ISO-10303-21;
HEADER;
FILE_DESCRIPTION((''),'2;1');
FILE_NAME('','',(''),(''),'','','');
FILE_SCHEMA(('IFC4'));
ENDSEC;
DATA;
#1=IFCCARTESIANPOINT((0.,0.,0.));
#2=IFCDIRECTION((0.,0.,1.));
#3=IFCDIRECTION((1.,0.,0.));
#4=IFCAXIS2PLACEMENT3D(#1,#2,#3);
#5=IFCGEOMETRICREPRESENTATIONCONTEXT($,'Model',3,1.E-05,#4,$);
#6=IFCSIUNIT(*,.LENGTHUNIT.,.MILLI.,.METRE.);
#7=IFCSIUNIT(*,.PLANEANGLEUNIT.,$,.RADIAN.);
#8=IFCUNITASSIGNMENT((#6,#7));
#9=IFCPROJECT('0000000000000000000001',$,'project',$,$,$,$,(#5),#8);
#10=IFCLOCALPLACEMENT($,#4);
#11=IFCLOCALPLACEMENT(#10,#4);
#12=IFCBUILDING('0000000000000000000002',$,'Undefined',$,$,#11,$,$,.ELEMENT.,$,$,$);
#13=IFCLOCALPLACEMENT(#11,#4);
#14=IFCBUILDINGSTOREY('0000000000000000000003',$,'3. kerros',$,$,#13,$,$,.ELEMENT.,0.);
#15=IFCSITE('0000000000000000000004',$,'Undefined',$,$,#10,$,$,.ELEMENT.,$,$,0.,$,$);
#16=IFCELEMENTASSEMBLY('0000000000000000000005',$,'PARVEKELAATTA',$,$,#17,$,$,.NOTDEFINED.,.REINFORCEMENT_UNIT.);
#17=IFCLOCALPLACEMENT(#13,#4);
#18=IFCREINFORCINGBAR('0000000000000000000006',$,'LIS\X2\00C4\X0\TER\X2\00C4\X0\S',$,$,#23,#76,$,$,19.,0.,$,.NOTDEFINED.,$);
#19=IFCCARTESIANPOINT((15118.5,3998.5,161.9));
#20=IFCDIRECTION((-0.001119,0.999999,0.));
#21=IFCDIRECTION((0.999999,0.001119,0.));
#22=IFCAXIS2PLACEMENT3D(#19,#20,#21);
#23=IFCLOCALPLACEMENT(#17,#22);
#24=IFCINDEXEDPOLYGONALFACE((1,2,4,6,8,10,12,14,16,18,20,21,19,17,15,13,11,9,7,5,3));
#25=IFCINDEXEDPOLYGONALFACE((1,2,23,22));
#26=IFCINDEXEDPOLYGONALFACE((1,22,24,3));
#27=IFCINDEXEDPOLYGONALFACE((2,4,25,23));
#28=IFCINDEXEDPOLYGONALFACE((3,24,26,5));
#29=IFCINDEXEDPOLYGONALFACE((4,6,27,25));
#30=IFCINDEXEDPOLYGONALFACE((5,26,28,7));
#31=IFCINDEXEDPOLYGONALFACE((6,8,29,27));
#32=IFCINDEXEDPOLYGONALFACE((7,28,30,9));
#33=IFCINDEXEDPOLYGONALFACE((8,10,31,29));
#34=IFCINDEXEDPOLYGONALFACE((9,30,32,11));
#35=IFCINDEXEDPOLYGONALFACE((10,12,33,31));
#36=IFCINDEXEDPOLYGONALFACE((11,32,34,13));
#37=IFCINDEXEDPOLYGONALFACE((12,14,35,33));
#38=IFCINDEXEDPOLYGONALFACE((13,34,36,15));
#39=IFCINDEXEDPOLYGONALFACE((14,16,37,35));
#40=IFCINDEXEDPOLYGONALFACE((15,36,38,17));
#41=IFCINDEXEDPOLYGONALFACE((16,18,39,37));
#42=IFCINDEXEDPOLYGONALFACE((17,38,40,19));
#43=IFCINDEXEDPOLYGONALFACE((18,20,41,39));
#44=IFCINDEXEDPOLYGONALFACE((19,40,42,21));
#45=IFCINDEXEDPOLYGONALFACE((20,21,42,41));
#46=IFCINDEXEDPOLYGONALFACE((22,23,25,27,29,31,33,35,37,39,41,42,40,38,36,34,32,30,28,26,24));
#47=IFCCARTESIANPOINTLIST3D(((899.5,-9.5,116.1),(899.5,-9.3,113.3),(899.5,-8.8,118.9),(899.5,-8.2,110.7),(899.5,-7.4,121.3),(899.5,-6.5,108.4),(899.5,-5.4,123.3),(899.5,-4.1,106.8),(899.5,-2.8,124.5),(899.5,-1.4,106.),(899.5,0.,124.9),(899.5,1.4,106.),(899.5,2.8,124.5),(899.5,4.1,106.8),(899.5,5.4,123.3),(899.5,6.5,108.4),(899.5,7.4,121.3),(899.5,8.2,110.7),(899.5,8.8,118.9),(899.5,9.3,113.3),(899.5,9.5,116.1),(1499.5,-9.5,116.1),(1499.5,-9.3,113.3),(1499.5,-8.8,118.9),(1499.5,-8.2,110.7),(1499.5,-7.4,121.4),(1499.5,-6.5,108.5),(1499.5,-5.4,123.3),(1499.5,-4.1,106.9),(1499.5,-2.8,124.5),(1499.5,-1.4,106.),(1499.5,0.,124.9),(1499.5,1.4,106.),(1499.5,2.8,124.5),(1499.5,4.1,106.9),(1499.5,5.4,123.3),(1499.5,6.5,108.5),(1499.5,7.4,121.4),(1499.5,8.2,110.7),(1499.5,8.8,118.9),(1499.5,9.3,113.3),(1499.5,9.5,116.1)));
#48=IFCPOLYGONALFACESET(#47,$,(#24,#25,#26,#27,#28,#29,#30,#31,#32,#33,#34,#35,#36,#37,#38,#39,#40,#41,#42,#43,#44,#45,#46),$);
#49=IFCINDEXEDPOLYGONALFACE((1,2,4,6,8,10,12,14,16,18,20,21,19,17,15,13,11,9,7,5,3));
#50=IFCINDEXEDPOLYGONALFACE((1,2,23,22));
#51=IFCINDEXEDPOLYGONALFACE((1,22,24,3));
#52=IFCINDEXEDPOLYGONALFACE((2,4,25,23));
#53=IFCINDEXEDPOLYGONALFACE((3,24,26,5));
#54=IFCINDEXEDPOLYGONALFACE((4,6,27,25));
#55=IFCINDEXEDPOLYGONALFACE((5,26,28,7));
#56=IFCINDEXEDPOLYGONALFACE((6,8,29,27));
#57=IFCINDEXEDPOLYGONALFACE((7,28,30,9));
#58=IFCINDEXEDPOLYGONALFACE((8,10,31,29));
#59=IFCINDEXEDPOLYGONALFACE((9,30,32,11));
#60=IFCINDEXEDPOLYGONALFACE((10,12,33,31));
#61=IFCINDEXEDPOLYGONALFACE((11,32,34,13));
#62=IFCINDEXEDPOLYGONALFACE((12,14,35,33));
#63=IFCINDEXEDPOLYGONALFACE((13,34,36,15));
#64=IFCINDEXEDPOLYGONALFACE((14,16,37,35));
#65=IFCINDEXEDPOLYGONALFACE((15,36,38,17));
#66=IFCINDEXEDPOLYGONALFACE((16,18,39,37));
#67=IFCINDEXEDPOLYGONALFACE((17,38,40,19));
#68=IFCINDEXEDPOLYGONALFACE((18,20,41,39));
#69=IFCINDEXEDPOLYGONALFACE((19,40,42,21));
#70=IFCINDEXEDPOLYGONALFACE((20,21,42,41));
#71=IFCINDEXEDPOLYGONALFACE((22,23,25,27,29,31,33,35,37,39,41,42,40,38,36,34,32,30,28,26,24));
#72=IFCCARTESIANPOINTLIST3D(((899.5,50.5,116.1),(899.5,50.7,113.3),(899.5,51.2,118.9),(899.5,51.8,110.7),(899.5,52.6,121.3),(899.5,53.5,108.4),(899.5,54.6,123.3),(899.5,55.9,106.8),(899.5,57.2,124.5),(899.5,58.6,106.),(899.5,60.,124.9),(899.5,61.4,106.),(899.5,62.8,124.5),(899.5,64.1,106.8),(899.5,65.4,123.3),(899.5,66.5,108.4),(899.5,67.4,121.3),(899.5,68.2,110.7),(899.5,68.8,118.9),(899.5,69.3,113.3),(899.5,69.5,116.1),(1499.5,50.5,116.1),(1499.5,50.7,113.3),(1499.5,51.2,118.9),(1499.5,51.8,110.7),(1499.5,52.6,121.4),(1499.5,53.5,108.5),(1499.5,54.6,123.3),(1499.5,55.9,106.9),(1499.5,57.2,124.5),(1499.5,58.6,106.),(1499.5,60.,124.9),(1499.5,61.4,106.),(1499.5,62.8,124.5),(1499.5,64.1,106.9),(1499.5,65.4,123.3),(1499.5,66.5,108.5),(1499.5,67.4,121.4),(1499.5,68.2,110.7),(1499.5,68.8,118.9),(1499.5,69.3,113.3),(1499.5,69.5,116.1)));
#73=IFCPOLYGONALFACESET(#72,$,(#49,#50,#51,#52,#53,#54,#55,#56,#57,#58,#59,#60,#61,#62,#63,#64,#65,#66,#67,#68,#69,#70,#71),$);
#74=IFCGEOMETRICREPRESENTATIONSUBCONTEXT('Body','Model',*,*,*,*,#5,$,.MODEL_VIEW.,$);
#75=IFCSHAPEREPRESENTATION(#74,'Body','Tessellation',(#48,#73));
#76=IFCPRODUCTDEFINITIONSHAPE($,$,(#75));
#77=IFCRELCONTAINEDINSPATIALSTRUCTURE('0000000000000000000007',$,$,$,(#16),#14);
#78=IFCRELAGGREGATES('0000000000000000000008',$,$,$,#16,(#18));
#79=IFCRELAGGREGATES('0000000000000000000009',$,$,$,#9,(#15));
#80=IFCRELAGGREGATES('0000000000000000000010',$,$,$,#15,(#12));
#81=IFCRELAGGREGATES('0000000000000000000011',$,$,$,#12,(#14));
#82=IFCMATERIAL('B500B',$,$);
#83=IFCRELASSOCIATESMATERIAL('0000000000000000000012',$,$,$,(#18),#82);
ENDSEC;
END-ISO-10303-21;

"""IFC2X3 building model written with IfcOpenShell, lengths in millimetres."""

from ifc_helpers import new_model, entity, si_unit, frame, origin_with_axes, place, context, subcontext, project, spatial, source, transform, mapped, material, element, aggregate, save


model = new_model("IFC2X3")

# Units and contexts
model_context = context("Model", 3, precision=1e-05, world=origin_with_axes())
body_context = subcontext(model_context, "Body", "Model", "MODEL_VIEW")
ifc_project = project(units=[si_unit("LENGTHUNIT", "METRE", prefix="MILLI"), si_unit("PLANEANGLEUNIT", "RADIAN")], contexts=[model_context])

# Site, building, storey
site_placement = place(None, origin_with_axes())
site = spatial("IfcSite", under=ifc_project, at=site_placement, Name="Undefined", CompositionType="ELEMENT", RefElevation=0.0)
building_placement = place(site_placement, origin_with_axes())
building = spatial("IfcBuilding", under=site, at=building_placement, Name="Undefined", CompositionType="ELEMENT")
storey_placement = place(building_placement, origin_with_axes())
storey = spatial("IfcBuildingStorey", under=building, at=storey_placement, Name="3. kerros", CompositionType="ELEMENT", Elevation=0.0)

# Element assembly, reinforcing bar
assembly_1_placement = place(storey_placement, origin_with_axes())
assembly_1 = element("IfcElementAssembly", 1, at=assembly_1_placement, inside=storey, Name="PARVEKELAATTA", AssemblyPlace="NOTDEFINED", PredefinedType="REINFORCEMENT_UNIT")
ifc_material_1 = material(Name="B500B")
shared_shape_1 = source(origin_with_axes(), body_context, "Body", "AdvancedSweptSolid", [
    entity("IfcSweptDiskSolid", entity("IfcTrimmedCurve", entity("IfcLine", entity("IfcCartesianPoint", [0.0, 0.0, 0.0]), entity("IfcVector", entity("IfcDirection", [1.0, 0.0, 0.000048]), 1.0)), [entity("IfcParameterValue", 0.0)], [entity("IfcParameterValue", 600.0)], True, "PARAMETER"), 9.5, None, 0.0, 600.0),
])
shared_shape_2 = source(origin_with_axes(), body_context, "Body", "AdvancedSweptSolid", [
    entity("IfcSweptDiskSolid", entity("IfcTrimmedCurve", entity("IfcLine", entity("IfcCartesianPoint", [0.0, 0.0, 0.0]), entity("IfcVector", entity("IfcDirection", [1.0, 0.0, 0.000048]), 1.0)), [entity("IfcParameterValue", 0.0)], [entity("IfcParameterValue", 600.0)], True, "PARAMETER"), 9.5, None, 0.0, 600.0),
])
reinforcing_bar_1_placement = place(assembly_1_placement, frame((15118.5, 3998.5, 161.9), z_axis=(-0.001119, 0.999999, 0.0), x_axis=(0.999999, 0.001119, 0.0)))
reinforcing_bar_1 = element("IfcReinforcingBar", 2, at=reinforcing_bar_1_placement, material=ifc_material_1, Name="LISÄTERÄS", BarRole="NOTDEFINED", CrossSectionArea=0.0, NominalDiameter=19.0, context=body_context, shape_type="MappedRepresentation", body=[
    mapped(shared_shape_1, transform((899.5, 0.0, 115.4))),
    mapped(shared_shape_2, transform((899.5, 60.0, 115.4))),
])
aggregate(assembly_1, [reinforcing_bar_1])

save(model, "model.ifc")
